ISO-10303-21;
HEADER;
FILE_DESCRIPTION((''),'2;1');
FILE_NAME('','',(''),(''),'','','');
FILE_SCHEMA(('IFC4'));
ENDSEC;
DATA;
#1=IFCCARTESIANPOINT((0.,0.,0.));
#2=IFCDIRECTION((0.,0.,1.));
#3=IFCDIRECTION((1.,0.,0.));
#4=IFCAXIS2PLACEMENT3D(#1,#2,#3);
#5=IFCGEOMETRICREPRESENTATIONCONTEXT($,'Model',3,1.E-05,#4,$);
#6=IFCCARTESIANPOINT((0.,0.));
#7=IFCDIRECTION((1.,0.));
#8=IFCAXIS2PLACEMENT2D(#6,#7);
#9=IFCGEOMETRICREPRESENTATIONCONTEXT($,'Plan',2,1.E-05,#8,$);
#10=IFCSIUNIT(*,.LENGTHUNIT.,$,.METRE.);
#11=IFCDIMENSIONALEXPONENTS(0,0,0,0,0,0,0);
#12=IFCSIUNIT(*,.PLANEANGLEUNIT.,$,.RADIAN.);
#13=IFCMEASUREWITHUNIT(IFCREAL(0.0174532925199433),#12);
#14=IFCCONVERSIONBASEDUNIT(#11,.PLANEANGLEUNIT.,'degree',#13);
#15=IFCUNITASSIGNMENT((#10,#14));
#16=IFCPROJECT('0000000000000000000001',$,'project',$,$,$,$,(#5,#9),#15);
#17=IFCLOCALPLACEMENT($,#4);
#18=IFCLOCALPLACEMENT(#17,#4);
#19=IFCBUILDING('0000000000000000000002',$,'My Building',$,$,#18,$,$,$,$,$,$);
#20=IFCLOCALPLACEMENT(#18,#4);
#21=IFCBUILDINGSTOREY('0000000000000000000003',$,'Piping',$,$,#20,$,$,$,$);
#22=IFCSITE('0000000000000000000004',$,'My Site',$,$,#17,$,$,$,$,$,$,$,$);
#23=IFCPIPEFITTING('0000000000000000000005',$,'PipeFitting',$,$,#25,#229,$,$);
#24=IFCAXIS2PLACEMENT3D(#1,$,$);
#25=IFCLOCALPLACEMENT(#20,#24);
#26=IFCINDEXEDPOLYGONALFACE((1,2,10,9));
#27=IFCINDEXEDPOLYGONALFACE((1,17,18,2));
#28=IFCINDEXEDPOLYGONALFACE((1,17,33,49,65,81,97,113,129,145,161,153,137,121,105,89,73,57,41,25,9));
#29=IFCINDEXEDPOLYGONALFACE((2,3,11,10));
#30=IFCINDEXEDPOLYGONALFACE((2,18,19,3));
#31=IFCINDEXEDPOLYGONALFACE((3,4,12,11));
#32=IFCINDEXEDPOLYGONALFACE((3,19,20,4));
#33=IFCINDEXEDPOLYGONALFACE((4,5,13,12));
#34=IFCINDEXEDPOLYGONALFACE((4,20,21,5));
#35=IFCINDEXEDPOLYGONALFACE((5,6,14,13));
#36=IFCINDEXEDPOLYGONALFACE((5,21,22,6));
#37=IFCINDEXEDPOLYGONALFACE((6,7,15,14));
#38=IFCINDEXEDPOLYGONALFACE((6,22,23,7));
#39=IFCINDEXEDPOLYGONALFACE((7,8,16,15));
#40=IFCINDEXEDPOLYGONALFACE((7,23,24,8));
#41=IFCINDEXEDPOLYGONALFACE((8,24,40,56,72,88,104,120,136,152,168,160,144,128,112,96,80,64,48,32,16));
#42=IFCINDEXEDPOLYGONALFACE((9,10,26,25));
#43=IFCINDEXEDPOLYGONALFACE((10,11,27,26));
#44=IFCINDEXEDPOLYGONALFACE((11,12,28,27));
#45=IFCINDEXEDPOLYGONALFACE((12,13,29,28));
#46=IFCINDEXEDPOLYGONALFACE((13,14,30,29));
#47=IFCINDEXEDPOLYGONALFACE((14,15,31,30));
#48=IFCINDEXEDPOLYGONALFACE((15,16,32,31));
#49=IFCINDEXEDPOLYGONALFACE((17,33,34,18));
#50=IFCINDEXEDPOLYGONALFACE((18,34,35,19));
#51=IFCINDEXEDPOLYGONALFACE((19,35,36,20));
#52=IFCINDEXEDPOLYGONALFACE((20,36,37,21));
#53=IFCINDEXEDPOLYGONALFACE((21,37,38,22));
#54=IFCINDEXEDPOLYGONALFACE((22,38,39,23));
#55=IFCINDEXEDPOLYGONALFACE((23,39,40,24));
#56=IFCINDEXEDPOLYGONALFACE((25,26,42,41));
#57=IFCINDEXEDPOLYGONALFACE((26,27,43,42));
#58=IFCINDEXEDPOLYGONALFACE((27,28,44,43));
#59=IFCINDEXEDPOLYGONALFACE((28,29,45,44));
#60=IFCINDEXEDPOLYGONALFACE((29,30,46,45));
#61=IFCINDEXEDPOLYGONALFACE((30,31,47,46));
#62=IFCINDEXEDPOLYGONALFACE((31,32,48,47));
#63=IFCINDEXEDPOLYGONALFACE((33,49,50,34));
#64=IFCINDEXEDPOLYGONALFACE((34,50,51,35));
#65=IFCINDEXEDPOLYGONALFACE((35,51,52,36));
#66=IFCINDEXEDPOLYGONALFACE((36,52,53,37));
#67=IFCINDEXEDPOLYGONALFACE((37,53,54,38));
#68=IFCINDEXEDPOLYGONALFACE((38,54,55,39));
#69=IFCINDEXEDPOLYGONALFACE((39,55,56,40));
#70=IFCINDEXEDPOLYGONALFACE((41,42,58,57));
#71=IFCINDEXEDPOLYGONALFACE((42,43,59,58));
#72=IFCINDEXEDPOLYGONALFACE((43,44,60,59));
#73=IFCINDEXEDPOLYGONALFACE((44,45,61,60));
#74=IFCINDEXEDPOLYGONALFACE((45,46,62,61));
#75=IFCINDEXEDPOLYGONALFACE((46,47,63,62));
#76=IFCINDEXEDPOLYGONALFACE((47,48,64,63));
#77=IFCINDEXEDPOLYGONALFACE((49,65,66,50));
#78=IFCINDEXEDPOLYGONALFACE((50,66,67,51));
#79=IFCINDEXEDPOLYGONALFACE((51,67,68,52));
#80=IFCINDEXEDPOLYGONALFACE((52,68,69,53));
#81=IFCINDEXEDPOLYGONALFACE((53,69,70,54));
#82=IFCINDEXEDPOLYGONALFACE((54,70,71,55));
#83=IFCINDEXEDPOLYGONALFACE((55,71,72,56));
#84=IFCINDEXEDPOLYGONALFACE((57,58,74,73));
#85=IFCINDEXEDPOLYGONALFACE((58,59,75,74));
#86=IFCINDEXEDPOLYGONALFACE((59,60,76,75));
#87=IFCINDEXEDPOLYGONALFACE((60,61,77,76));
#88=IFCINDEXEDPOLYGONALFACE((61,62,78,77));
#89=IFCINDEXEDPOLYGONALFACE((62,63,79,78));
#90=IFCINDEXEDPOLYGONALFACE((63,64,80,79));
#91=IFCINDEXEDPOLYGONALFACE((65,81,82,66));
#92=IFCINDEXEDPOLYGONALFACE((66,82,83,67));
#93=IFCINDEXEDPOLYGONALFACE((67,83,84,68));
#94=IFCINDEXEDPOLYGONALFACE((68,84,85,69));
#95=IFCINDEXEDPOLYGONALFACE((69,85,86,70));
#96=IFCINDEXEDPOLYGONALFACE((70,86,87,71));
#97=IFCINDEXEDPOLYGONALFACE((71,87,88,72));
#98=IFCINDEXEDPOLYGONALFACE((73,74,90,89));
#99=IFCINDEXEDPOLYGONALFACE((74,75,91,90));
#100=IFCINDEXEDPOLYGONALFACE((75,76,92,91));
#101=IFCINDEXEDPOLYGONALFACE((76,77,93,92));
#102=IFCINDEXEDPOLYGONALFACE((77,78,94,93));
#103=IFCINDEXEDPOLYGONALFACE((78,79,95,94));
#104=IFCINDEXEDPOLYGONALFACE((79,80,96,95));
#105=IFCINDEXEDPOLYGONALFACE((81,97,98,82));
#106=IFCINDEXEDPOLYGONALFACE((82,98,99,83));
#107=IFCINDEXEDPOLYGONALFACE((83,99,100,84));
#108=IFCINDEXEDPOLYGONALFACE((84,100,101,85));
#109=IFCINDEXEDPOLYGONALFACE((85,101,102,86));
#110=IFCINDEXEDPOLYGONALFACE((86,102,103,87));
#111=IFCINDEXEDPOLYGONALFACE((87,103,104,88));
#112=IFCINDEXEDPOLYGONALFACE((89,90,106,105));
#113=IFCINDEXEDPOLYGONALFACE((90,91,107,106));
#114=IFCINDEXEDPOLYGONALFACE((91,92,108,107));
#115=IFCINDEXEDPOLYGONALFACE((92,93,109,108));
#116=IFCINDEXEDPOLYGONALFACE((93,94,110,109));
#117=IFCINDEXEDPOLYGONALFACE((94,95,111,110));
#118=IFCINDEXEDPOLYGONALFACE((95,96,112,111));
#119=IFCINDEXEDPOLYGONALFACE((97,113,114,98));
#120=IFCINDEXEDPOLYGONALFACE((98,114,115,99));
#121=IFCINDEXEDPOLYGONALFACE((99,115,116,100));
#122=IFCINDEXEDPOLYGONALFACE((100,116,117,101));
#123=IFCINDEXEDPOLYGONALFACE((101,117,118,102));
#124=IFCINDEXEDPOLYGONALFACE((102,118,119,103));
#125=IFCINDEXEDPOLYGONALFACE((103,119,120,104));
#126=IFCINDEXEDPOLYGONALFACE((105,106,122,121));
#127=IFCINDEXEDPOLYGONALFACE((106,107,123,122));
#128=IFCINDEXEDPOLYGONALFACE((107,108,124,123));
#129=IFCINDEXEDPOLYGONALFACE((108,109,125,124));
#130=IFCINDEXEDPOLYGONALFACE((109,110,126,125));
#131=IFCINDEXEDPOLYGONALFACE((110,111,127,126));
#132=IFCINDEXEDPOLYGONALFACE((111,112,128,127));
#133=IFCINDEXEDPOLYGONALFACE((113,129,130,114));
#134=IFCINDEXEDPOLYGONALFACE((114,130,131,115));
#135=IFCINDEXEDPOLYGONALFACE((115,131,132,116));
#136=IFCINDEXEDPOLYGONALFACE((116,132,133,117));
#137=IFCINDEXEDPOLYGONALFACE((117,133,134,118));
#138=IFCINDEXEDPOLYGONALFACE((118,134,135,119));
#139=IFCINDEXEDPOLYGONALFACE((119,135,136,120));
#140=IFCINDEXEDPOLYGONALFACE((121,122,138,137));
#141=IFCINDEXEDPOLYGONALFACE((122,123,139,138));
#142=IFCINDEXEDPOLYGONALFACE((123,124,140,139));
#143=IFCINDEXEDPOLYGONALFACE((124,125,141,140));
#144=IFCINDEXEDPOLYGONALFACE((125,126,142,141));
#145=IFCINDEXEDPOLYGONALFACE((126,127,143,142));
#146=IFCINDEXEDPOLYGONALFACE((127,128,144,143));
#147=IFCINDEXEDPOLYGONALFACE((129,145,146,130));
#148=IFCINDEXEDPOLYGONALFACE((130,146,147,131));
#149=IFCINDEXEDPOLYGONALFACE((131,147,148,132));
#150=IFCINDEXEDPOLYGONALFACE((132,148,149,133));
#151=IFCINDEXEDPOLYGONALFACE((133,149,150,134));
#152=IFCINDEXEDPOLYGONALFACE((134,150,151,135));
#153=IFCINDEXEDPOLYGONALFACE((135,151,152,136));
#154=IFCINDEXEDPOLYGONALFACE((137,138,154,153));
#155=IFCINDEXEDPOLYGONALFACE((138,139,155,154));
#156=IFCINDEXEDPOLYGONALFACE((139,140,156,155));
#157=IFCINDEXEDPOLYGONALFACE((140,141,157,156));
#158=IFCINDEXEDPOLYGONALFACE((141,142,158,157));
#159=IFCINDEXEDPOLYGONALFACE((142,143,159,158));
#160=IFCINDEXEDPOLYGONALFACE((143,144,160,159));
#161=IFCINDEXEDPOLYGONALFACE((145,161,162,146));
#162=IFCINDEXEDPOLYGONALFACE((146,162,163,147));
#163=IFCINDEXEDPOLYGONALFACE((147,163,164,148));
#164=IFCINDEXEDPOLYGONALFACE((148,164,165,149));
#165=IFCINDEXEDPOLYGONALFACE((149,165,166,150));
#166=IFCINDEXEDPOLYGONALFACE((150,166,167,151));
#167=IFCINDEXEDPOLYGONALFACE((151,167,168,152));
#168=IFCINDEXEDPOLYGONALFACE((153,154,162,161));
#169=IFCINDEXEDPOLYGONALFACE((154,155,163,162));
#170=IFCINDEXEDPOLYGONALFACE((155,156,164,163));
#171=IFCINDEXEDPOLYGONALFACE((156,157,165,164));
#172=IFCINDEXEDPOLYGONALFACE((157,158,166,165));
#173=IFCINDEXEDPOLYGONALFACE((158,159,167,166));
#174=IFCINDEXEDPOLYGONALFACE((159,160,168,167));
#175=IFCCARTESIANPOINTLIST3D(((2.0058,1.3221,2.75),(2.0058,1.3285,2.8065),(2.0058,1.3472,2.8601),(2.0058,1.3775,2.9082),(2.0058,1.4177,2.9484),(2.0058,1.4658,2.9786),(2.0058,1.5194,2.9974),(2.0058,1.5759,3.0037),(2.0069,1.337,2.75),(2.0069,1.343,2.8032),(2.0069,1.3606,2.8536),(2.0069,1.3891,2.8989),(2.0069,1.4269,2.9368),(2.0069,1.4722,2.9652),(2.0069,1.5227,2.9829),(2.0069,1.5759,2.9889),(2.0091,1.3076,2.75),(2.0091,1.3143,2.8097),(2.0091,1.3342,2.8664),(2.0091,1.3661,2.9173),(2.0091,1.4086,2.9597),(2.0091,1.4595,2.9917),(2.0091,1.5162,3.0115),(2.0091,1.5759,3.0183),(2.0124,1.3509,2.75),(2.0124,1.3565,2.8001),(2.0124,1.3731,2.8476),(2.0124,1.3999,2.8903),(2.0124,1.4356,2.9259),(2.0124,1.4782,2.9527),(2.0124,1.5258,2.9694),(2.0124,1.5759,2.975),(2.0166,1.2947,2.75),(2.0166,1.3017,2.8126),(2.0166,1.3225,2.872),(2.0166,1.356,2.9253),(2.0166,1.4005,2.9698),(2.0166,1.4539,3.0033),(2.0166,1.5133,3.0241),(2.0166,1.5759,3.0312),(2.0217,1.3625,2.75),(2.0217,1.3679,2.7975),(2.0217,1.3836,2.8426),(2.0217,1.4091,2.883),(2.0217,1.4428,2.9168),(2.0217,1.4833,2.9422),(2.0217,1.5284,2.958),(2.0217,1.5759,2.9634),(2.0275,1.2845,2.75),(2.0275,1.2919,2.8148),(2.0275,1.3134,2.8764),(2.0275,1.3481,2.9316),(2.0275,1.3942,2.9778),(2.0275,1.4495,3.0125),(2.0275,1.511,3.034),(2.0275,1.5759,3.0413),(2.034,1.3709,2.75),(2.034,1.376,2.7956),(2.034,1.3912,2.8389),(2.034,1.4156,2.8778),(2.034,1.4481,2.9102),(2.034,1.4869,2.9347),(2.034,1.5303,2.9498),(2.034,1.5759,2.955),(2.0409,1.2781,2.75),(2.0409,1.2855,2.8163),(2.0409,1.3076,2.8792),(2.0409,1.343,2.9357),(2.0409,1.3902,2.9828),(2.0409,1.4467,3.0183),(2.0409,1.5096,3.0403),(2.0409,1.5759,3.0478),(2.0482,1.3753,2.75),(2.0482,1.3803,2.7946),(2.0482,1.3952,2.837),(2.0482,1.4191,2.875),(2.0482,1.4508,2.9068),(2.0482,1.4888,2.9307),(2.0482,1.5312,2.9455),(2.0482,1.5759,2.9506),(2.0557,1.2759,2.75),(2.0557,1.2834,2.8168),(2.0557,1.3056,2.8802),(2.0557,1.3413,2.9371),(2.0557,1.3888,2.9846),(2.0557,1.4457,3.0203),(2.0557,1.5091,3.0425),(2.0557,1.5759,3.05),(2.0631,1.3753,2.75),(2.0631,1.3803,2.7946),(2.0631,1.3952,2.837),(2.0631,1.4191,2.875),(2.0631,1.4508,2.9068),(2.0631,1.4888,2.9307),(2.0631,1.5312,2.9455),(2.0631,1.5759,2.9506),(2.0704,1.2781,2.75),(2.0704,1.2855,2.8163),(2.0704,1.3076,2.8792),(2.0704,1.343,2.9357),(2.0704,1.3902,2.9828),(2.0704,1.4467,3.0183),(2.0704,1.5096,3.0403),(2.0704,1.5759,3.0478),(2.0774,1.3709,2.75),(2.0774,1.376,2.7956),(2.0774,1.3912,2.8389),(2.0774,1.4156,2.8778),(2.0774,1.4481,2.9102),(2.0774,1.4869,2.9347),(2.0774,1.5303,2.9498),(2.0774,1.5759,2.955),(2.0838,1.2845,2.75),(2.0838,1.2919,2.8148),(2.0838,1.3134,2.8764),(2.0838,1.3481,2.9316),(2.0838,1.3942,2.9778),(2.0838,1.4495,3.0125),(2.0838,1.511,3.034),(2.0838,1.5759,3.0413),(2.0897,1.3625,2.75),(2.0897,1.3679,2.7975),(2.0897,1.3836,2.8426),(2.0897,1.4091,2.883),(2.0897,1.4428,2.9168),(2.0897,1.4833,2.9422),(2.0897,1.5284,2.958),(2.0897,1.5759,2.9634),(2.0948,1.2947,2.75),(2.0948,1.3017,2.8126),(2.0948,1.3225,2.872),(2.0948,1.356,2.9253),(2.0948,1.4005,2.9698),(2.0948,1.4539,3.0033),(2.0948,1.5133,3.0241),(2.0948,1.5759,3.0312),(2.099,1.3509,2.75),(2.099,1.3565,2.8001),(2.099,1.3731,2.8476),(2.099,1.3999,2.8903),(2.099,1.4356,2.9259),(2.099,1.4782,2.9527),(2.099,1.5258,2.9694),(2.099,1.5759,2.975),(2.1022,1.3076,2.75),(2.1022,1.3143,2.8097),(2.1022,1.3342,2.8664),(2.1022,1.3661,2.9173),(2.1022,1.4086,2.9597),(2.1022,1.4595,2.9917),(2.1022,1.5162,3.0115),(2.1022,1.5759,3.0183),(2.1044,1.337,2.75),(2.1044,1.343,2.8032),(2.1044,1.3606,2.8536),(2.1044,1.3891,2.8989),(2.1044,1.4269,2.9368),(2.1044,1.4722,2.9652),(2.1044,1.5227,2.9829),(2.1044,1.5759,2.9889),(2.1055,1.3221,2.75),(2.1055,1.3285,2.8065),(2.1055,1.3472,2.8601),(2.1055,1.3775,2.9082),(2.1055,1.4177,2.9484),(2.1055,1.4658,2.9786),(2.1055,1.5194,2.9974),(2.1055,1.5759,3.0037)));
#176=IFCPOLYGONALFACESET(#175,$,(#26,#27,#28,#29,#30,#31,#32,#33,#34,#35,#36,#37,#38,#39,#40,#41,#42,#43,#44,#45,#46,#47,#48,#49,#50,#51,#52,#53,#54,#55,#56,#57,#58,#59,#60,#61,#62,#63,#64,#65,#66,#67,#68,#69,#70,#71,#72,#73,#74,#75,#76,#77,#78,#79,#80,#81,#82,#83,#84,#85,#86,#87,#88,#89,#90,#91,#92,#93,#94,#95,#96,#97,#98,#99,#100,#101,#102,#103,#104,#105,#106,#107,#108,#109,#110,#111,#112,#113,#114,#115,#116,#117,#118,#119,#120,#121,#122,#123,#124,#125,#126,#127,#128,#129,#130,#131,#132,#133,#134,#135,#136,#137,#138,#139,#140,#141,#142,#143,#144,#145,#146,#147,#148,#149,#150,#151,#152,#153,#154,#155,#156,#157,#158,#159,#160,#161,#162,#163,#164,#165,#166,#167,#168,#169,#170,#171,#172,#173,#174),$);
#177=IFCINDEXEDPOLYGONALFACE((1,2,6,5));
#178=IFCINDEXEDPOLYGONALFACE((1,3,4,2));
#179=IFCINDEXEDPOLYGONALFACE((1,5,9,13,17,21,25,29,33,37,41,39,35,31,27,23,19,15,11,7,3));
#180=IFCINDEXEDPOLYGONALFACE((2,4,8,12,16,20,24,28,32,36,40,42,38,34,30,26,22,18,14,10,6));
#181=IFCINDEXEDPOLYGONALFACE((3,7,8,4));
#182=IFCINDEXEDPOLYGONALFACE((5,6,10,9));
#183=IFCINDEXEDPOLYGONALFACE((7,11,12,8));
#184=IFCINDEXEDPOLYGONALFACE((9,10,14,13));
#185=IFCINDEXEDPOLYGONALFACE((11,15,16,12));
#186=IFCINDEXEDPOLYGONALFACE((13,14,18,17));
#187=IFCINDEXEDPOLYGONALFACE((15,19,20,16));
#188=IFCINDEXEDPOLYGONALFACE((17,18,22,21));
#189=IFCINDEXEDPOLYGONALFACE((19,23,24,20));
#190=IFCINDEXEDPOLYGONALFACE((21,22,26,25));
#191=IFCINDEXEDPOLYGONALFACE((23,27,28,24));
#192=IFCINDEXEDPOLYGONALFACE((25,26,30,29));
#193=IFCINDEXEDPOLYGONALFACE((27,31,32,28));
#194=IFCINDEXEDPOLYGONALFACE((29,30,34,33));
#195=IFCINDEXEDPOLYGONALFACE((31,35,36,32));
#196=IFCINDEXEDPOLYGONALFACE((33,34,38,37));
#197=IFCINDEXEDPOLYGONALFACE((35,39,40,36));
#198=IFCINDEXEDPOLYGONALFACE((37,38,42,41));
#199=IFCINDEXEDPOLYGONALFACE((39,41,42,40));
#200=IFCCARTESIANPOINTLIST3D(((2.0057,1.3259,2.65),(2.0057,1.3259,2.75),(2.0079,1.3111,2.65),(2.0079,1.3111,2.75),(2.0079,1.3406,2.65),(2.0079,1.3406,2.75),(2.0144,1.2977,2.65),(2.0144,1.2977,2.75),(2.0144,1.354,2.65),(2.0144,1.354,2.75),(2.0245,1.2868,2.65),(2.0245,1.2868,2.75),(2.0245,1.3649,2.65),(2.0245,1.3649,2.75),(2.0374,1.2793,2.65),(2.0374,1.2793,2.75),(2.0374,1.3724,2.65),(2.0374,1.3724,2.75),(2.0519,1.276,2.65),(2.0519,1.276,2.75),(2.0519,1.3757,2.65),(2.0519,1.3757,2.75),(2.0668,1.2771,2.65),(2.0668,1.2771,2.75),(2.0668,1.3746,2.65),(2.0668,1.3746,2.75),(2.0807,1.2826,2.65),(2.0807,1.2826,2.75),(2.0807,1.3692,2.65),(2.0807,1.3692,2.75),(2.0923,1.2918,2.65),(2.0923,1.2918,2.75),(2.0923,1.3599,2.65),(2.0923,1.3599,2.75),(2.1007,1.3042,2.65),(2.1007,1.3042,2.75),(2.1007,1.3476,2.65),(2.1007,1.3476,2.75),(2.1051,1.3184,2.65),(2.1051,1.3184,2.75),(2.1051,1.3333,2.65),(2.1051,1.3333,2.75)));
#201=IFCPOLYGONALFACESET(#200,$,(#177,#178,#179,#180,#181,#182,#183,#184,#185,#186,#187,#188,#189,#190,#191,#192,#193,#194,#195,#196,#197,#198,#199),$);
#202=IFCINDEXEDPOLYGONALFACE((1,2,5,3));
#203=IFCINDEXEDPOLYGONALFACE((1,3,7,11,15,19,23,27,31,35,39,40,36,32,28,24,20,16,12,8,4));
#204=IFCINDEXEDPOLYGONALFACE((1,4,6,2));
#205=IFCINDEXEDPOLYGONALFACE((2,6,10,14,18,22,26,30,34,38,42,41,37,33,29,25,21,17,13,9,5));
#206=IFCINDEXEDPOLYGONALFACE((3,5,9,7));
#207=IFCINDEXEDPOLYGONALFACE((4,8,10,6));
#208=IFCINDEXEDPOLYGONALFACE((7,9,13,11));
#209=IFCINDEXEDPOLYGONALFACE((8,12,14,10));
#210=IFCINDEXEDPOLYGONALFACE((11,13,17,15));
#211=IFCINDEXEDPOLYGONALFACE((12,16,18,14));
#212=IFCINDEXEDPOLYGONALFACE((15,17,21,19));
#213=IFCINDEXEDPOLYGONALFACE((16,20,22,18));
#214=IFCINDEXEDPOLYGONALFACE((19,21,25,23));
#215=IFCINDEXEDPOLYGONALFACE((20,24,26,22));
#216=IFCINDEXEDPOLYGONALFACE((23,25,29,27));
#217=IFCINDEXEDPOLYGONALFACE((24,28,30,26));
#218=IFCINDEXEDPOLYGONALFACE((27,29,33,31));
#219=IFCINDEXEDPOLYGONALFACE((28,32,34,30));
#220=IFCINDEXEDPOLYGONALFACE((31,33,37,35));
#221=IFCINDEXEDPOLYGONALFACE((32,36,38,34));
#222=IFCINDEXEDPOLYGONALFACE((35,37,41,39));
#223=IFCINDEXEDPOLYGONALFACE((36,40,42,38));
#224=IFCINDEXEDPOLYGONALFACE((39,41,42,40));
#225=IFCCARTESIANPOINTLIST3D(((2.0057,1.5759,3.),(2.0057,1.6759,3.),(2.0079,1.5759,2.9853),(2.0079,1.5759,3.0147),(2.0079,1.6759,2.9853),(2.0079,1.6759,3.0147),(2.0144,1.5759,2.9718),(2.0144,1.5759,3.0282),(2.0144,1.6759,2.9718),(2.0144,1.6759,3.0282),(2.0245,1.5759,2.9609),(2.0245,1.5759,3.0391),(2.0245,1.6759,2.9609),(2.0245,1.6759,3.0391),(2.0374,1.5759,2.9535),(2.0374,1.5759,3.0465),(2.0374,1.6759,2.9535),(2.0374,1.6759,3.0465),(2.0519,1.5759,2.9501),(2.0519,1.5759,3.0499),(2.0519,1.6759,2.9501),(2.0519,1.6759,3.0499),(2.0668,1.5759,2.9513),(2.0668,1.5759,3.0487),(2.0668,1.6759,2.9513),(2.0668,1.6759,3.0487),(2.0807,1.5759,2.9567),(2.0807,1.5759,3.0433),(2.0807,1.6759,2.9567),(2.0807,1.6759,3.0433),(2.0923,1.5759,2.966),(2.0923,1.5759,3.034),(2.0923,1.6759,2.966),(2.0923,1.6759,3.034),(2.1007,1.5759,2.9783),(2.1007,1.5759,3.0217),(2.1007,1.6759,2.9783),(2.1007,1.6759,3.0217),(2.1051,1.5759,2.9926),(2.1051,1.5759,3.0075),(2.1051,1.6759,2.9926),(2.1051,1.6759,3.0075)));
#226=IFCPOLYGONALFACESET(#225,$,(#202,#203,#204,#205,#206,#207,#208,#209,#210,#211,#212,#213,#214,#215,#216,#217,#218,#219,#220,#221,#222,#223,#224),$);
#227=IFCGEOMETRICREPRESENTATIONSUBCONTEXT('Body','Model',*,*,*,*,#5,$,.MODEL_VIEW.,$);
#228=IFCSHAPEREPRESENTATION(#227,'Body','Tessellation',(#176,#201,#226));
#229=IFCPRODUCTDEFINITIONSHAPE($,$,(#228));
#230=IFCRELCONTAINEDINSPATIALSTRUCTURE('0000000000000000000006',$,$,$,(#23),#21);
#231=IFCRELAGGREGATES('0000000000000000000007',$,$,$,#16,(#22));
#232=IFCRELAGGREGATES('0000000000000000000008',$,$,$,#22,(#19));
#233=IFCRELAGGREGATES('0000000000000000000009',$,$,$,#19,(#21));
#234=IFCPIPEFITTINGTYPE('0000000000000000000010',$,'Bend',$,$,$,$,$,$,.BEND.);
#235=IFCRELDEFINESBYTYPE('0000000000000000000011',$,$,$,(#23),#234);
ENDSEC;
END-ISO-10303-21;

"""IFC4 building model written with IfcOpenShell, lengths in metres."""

from ifc_helpers import new_model, entity, si_unit, converted_unit, frame, origin_with_axes, origin_2d_with_axis, place, context, subcontext, project, spatial, circle, extrude, source, transform, mapped, type_object, type_shapes, element, save


model = new_model("IFC4")

# Units and contexts
model_context = context("Model", 3, precision=1e-05, world=origin_with_axes())
plan_context = context("Plan", 2, precision=1e-05, world=origin_2d_with_axis())
body_context = subcontext(model_context, "Body", "Model", "MODEL_VIEW")
ifc_project = project(units=[si_unit("LENGTHUNIT", "METRE"), converted_unit("PLANEANGLEUNIT", "degree", entity("IfcReal", 0.0174532925199433), si_unit("PLANEANGLEUNIT", "RADIAN"), dimensions=[0, 0, 0, 0, 0, 0, 0])], contexts=[model_context, plan_context])

# Site, building, storey
site_placement = place(None, origin_with_axes())
site = spatial("IfcSite", under=ifc_project, at=site_placement, Name="My Site")
building_placement = place(site_placement, origin_with_axes())
building = spatial("IfcBuilding", under=site, at=building_placement, Name="My Building")
storey_placement = place(building_placement, origin_with_axes())
storey = spatial("IfcBuildingStorey", under=building, at=storey_placement, Name="Piping")

# Pipe fitting
pipe_fitting_type = type_object("IfcPipeFittingType", Name="Bend", PredefinedType="BEND")
shared_shape = source(origin_with_axes(), body_context, "Body", "SolidModel", [
    entity("IfcSweptDiskSolid", entity("IfcIndexedPolyCurve", entity("IfcCartesianPointList3D", [[0.0, 0.0, -0.1], [0.0, 0.0732, -0.2768], [0.0, 0.25, -0.35]]), [entity("IfcArcIndex", [1, 2, 3])]), 0.05),
    extrude(circle(Radius=0.05), origin_with_axes(), (0.0, 0.0, -1.0), 0.1),
    extrude(circle(Radius=0.05), frame((0.0, 0.25, -0.35), z_axis=(0.0, 1.0, 0.0), x_axis=(1.0, 0.0, 0.0)), (0.0, 0.0, 1.0), 0.1),
])
type_shapes(pipe_fitting_type, [shared_shape])
for number, where, z_axis, x_axis, name in (
    (1, (2.0557, 1.3259, 2.65), (0.0, 0.0, -1.0), (-1.0, 0.0, 0.0), "PipeFitting"),
):
    element("IfcPipeFitting", number, at=place(storey_placement, frame(where, z_axis=z_axis, x_axis=x_axis)), inside=storey, type_object=pipe_fitting_type, Name=name, context=body_context, shape_type="MappedRepresentation", body=[
        mapped(shared_shape, transform((0.0, 0.0, 0.0), x_axis=(1.0, 0.0, 0.0), y_axis=(0.0, 1.0, 0.0), z_axis=(0.0, 0.0, 1.0), scale=1.0)),
    ])

save(model, "model.ifc")
